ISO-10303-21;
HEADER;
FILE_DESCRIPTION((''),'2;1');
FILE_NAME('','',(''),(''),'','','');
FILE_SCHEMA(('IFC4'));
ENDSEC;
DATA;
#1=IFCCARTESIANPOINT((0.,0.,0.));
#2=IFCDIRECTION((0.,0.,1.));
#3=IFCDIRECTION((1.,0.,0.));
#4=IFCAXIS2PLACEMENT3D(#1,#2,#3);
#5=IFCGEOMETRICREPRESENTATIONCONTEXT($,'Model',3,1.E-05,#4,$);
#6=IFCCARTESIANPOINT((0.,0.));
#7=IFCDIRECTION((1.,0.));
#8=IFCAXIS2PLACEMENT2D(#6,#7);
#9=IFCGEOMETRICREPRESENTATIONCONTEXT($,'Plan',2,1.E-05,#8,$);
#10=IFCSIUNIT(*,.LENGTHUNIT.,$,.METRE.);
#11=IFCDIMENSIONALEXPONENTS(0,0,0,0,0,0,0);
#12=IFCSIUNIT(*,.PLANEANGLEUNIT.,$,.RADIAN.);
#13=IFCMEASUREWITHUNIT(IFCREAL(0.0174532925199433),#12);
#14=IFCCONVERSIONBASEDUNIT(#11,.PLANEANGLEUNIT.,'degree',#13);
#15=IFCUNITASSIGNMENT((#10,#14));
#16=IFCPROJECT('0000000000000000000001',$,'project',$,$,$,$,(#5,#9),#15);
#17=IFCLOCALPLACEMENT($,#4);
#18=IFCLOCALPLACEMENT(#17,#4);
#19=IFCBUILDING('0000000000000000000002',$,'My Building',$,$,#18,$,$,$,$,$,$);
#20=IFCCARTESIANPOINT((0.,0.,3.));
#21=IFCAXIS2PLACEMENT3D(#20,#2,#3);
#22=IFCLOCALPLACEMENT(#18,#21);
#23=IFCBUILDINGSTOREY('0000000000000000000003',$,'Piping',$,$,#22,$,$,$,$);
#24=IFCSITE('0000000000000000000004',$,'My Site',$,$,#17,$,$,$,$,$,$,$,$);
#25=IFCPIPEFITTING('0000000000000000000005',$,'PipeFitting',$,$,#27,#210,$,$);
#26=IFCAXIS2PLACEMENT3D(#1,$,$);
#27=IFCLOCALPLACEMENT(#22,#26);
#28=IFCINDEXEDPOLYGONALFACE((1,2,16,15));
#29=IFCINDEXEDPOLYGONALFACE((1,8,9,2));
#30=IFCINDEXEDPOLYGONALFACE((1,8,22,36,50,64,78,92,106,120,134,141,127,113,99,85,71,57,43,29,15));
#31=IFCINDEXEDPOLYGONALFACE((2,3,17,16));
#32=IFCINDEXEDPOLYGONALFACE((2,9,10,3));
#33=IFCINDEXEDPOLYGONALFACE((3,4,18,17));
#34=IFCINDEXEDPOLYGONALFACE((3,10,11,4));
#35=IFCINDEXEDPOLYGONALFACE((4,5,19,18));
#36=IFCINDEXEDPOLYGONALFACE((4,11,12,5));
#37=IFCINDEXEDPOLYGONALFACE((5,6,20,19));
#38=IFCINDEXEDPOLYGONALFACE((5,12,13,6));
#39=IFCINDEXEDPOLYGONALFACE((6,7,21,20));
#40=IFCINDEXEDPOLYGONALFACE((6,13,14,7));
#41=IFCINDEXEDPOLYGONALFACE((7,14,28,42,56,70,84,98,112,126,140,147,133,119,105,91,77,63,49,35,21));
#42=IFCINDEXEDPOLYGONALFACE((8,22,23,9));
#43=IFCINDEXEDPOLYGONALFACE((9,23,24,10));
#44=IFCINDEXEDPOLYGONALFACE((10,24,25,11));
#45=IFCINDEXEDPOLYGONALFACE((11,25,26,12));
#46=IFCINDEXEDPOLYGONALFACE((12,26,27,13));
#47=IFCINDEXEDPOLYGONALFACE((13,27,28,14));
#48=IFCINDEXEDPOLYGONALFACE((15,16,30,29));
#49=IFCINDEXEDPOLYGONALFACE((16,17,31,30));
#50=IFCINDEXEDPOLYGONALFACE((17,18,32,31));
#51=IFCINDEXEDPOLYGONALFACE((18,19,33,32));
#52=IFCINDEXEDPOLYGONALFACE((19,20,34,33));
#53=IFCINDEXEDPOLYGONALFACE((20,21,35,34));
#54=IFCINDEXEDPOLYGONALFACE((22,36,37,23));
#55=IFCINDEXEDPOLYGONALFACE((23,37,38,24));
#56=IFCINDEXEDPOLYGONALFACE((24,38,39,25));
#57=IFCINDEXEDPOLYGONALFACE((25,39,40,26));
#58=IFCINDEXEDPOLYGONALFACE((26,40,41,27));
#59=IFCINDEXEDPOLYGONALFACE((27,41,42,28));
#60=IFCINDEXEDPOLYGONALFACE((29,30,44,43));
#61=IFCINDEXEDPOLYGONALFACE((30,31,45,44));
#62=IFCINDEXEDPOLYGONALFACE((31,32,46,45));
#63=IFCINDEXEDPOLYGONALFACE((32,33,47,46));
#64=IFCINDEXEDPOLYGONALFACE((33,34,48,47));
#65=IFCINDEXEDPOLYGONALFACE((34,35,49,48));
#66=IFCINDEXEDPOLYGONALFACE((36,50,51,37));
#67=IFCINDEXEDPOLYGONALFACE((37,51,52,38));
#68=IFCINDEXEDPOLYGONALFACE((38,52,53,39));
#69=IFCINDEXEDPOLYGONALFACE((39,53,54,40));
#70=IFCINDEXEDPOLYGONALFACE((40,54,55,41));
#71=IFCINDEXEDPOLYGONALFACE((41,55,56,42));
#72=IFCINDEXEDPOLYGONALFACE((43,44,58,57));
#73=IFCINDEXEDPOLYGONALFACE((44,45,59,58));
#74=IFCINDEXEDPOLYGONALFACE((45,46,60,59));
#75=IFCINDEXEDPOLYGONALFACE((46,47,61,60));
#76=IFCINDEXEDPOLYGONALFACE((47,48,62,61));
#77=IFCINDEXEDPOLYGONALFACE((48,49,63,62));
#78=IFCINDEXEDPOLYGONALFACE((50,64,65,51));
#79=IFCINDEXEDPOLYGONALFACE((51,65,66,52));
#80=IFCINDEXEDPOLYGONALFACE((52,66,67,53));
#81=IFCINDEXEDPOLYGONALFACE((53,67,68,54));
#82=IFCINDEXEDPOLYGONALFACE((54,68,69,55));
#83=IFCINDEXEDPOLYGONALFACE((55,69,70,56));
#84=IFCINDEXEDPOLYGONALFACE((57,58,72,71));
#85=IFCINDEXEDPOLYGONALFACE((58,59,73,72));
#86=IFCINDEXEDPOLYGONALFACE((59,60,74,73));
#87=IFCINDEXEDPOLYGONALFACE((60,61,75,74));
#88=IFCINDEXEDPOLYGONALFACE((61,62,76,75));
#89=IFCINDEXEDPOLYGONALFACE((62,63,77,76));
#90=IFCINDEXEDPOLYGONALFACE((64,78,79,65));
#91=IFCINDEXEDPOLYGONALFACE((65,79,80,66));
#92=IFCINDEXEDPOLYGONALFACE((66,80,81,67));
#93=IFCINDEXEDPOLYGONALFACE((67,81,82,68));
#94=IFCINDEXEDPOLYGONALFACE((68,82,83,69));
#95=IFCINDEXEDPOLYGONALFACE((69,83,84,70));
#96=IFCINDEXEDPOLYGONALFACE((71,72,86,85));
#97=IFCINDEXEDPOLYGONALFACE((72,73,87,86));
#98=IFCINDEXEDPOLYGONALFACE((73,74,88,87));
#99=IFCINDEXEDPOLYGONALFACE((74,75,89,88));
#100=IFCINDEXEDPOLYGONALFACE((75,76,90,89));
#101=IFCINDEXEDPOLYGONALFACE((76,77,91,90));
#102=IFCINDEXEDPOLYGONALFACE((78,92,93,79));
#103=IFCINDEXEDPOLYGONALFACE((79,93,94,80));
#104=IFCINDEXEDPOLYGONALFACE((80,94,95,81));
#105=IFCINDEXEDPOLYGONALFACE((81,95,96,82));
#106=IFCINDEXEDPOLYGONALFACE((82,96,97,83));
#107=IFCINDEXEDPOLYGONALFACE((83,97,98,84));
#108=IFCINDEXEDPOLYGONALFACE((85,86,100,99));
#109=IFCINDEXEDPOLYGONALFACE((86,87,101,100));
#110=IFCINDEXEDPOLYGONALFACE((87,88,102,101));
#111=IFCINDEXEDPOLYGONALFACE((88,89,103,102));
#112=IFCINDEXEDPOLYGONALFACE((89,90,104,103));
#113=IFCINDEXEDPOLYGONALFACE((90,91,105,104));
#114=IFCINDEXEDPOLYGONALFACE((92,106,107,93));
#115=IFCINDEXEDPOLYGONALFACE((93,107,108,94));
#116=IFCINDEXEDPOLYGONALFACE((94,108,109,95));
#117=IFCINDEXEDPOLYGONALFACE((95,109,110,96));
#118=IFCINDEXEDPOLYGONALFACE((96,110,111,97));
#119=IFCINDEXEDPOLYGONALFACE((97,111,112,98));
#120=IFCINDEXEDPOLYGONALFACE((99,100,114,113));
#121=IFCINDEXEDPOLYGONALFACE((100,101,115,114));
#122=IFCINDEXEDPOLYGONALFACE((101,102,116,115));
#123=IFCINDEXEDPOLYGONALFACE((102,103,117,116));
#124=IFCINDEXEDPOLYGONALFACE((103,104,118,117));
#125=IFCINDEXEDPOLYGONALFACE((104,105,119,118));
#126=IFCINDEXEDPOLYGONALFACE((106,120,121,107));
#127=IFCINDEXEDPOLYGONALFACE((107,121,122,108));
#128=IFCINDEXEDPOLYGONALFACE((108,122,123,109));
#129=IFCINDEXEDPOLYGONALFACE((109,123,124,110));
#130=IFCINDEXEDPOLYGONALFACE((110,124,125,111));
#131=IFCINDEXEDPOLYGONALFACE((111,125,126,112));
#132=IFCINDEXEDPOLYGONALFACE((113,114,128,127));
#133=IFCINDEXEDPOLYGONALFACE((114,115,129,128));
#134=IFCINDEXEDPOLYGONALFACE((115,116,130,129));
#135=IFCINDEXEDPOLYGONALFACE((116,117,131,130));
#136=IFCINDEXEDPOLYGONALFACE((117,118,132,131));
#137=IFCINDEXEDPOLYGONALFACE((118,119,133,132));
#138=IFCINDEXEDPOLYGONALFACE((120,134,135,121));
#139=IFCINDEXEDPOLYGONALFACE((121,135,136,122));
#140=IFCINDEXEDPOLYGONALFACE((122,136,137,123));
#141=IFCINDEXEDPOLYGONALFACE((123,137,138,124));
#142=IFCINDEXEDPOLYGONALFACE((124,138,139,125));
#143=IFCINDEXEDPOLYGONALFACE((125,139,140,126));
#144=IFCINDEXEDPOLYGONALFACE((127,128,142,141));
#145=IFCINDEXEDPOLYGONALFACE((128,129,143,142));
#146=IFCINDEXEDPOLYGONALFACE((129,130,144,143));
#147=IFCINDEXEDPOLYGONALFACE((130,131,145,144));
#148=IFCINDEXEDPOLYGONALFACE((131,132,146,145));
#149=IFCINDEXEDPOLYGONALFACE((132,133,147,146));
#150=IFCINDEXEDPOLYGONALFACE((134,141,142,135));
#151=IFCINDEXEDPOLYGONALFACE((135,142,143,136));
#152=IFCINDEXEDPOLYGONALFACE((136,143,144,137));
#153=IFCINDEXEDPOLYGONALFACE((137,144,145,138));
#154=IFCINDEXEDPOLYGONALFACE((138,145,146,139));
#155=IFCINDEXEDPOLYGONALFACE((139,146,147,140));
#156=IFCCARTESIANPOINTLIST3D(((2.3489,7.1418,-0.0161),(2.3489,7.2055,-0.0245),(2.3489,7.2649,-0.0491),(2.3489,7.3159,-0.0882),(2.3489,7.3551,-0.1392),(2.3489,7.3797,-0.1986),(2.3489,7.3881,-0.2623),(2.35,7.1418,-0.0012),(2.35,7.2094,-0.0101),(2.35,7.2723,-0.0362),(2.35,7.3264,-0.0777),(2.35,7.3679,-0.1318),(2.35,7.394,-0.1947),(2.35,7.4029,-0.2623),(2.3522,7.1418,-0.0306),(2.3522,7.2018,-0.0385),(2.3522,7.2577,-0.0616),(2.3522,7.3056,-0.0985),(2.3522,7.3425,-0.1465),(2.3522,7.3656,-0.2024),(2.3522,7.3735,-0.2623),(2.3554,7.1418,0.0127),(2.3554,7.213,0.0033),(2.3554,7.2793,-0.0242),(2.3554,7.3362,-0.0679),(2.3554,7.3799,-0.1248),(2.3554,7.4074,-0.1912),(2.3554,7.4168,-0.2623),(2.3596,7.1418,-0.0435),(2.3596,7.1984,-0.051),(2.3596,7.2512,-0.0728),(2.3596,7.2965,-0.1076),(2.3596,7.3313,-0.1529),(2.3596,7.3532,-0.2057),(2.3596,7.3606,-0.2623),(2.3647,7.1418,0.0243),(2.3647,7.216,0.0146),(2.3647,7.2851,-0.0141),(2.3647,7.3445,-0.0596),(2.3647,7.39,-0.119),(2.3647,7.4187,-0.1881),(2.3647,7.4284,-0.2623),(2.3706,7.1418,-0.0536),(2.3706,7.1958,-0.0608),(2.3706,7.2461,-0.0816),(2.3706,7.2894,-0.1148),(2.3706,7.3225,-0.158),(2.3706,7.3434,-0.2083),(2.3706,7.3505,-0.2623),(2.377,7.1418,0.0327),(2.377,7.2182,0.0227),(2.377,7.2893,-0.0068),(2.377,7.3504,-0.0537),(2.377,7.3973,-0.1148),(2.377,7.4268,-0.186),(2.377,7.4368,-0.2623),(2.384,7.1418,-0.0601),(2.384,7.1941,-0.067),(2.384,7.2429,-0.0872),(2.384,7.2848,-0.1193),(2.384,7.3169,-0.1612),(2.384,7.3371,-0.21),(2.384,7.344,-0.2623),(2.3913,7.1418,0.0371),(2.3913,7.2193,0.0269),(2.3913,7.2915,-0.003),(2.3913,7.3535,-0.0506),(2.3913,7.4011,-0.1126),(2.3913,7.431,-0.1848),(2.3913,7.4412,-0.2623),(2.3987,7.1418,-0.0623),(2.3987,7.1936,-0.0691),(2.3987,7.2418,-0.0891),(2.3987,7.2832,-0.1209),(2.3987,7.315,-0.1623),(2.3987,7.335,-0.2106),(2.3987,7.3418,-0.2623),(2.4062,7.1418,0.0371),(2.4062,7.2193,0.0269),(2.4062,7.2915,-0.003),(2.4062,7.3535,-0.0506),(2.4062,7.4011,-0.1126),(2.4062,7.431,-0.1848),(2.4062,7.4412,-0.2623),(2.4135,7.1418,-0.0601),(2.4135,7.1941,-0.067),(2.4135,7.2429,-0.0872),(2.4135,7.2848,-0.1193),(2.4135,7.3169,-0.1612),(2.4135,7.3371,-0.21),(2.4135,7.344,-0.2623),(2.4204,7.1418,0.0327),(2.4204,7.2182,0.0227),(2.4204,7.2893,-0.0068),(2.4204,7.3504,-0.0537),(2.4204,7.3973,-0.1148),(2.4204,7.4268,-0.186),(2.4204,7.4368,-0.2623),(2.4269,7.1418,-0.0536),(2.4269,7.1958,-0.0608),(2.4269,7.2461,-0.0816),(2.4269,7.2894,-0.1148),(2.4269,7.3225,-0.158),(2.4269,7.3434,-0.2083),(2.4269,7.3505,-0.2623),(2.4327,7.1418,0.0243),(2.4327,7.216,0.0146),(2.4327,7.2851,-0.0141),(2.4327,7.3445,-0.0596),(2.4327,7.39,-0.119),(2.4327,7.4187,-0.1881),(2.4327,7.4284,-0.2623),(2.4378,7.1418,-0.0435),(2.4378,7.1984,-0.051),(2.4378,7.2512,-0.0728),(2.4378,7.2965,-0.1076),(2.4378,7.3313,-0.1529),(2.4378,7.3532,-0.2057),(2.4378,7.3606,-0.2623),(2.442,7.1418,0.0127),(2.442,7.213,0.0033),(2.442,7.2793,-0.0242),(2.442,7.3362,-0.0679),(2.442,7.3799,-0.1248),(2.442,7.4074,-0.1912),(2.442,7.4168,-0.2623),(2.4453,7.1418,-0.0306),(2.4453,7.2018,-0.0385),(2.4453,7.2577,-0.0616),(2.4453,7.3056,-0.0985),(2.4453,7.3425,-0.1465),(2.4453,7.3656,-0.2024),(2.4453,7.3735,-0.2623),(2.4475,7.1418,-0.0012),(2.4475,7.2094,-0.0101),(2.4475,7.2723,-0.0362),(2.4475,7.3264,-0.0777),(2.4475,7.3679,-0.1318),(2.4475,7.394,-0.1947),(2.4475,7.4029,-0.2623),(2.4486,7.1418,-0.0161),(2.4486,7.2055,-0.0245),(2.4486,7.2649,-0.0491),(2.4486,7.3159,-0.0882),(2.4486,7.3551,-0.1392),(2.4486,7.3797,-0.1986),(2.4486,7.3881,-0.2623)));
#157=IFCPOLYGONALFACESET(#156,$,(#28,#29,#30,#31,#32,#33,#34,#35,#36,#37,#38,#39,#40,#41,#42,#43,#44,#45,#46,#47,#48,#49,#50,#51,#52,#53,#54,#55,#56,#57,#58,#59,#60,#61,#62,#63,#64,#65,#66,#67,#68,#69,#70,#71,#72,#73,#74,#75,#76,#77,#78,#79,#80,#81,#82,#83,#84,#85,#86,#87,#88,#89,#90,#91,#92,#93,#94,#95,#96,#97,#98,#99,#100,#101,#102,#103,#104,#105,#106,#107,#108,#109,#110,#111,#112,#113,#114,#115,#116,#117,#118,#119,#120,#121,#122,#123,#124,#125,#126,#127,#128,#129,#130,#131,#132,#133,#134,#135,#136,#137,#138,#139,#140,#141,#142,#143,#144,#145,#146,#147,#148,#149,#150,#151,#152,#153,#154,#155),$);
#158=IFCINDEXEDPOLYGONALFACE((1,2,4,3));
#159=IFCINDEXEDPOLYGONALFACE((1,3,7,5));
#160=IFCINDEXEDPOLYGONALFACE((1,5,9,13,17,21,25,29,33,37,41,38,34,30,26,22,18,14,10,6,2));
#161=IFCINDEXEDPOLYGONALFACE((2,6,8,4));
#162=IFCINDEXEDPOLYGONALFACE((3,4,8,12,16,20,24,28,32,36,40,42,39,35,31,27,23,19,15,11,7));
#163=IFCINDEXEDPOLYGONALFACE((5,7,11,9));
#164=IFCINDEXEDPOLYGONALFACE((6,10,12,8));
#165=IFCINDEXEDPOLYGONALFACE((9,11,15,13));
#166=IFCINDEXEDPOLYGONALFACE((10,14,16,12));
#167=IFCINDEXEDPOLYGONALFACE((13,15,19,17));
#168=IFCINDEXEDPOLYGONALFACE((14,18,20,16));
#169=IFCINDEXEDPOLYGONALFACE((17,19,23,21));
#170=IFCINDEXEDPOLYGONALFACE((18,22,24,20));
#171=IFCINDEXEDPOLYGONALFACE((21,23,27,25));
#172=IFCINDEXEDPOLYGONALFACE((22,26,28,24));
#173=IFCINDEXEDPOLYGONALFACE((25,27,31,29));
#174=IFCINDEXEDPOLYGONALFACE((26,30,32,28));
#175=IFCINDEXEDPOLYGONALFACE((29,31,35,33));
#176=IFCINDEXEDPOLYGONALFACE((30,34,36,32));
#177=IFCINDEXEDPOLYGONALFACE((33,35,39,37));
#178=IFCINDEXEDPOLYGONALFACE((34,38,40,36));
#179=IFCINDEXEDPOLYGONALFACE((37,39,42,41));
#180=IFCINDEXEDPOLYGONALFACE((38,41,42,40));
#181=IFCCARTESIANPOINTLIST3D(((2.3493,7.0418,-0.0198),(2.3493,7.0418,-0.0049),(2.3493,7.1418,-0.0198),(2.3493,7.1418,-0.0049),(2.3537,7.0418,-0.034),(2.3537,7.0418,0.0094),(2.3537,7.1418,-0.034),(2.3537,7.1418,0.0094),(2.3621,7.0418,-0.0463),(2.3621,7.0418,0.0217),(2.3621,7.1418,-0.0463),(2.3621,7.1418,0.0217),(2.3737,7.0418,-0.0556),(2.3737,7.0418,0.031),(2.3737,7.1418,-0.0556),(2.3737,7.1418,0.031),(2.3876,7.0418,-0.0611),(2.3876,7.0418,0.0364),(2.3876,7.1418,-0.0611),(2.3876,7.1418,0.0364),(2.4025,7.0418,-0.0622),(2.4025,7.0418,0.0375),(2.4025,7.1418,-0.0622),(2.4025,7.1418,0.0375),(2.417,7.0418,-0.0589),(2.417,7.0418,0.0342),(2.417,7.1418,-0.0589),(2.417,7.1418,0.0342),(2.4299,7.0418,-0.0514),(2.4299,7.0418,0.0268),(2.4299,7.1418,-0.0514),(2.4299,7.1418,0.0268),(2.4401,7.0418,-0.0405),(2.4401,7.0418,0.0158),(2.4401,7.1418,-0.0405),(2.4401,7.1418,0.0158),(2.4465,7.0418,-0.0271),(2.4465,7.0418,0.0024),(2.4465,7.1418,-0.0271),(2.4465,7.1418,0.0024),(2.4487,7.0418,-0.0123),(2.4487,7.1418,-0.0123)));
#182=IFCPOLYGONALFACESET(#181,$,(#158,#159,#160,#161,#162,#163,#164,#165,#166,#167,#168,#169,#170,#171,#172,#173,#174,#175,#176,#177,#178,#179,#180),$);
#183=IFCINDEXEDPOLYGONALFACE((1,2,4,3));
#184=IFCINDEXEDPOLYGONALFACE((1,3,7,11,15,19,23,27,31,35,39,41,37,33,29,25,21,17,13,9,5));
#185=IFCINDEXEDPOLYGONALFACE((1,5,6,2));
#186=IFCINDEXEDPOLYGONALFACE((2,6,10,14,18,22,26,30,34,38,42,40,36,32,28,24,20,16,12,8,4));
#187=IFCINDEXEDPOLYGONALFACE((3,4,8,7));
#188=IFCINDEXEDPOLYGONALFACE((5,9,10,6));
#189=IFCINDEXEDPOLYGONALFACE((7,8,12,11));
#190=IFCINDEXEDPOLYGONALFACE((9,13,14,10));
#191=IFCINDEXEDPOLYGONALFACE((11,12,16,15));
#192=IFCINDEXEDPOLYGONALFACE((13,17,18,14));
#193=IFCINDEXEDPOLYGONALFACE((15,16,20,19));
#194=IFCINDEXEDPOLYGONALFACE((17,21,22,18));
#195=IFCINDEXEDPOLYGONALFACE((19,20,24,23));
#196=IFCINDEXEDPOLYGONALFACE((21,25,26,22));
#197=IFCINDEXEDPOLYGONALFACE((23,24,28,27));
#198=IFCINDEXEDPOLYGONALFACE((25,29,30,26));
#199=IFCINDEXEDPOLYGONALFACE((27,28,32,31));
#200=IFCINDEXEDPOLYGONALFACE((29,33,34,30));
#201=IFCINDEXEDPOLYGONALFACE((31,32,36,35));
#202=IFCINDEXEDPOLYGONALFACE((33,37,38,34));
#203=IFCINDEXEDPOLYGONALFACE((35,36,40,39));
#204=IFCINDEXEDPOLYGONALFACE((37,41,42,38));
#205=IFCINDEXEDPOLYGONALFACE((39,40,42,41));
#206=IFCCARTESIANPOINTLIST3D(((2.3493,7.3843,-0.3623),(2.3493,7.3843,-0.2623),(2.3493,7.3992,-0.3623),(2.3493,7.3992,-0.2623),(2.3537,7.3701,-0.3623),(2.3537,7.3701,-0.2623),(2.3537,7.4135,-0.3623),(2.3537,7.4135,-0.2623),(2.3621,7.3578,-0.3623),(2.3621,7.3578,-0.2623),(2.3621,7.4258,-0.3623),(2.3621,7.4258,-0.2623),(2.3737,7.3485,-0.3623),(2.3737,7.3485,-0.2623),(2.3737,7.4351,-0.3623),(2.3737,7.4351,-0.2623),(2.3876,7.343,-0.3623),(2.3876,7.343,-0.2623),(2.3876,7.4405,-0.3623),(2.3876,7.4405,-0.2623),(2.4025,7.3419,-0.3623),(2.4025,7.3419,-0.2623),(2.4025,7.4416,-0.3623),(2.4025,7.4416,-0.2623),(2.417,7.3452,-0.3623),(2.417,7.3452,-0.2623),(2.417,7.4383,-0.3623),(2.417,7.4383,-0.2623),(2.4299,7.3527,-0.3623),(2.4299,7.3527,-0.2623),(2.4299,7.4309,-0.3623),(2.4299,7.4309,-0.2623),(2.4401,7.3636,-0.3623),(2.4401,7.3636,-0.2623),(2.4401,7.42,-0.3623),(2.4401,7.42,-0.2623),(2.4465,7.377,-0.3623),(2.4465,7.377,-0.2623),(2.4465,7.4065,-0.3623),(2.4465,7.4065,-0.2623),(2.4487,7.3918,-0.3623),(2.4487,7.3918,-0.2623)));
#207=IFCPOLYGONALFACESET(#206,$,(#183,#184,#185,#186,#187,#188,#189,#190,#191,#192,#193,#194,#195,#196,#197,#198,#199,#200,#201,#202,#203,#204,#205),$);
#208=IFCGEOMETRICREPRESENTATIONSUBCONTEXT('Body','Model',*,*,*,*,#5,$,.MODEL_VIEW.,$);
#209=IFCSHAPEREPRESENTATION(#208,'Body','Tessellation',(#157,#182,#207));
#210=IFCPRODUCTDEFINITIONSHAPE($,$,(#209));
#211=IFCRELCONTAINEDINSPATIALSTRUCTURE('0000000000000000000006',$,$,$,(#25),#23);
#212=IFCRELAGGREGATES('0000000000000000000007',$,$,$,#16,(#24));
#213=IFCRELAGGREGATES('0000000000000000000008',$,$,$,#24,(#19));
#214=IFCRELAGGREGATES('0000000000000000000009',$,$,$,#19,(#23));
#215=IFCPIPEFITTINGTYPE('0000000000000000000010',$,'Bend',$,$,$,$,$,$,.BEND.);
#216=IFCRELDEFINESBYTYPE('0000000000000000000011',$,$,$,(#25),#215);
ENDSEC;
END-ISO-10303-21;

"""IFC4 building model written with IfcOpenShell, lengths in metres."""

from ifc_helpers import new_model, entity, si_unit, converted_unit, frame, origin_with_axes, origin_2d_with_axis, place, context, subcontext, project, spatial, circle, extrude, source, transform, mapped, type_object, type_shapes, element, save


model = new_model("IFC4")

# Units and contexts
model_context = context("Model", 3, precision=1e-05, world=origin_with_axes())
plan_context = context("Plan", 2, precision=1e-05, world=origin_2d_with_axis())
body_context = subcontext(model_context, "Body", "Model", "MODEL_VIEW")
ifc_project = project(units=[si_unit("LENGTHUNIT", "METRE"), converted_unit("PLANEANGLEUNIT", "degree", entity("IfcReal", 0.0174532925199433), si_unit("PLANEANGLEUNIT", "RADIAN"), dimensions=[0, 0, 0, 0, 0, 0, 0])], contexts=[model_context, plan_context])

# Site, building, storey
site_placement = place(None, origin_with_axes())
site = spatial("IfcSite", under=ifc_project, at=site_placement, Name="My Site")
building_placement = place(site_placement, origin_with_axes())
building = spatial("IfcBuilding", under=site, at=building_placement, Name="My Building")
storey_placement = place(building_placement, frame((0.0, 0.0, 3.0), z_axis=(0.0, 0.0, 1.0), x_axis=(1.0, 0.0, 0.0)))
storey = spatial("IfcBuildingStorey", under=building, at=storey_placement, Name="Piping")

# Pipe fitting
pipe_fitting_type = type_object("IfcPipeFittingType", Name="Bend", PredefinedType="BEND")
shared_shape = source(origin_with_axes(), body_context, "Body", "SolidModel", [
    entity("IfcSweptDiskSolid", entity("IfcIndexedPolyCurve", entity("IfcCartesianPointList3D", [[0.0, 0.0, -0.1], [0.0, -0.0732, -0.2768], [0.0, -0.25, -0.35]]), [entity("IfcArcIndex", [1, 2, 3])]), 0.05),
    extrude(circle(Radius=0.05), origin_with_axes(), (0.0, 0.0, -1.0), 0.1),
    extrude(circle(Radius=0.05), frame((0.0, -0.25, -0.35), z_axis=(0.0, -1.0, 0.0), x_axis=(1.0, 0.0, 0.0)), (0.0, 0.0, 1.0), 0.1),
])
type_shapes(pipe_fitting_type, [shared_shape])
for number, where, z_axis, x_axis, name in (
    (1, (2.3987, 7.0418, -0.0123), (0.0, -1.0, 0.0), (1.0, 0.0, 0.0), "PipeFitting"),
):
    element("IfcPipeFitting", number, at=place(storey_placement, frame(where, z_axis=z_axis, x_axis=x_axis)), inside=storey, type_object=pipe_fitting_type, Name=name, context=body_context, shape_type="MappedRepresentation", body=[
        mapped(shared_shape, transform((0.0, 0.0, 0.0), x_axis=(1.0, 0.0, 0.0), y_axis=(0.0, 1.0, 0.0), z_axis=(0.0, 0.0, 1.0), scale=1.0)),
    ])

save(model, "model.ifc")
